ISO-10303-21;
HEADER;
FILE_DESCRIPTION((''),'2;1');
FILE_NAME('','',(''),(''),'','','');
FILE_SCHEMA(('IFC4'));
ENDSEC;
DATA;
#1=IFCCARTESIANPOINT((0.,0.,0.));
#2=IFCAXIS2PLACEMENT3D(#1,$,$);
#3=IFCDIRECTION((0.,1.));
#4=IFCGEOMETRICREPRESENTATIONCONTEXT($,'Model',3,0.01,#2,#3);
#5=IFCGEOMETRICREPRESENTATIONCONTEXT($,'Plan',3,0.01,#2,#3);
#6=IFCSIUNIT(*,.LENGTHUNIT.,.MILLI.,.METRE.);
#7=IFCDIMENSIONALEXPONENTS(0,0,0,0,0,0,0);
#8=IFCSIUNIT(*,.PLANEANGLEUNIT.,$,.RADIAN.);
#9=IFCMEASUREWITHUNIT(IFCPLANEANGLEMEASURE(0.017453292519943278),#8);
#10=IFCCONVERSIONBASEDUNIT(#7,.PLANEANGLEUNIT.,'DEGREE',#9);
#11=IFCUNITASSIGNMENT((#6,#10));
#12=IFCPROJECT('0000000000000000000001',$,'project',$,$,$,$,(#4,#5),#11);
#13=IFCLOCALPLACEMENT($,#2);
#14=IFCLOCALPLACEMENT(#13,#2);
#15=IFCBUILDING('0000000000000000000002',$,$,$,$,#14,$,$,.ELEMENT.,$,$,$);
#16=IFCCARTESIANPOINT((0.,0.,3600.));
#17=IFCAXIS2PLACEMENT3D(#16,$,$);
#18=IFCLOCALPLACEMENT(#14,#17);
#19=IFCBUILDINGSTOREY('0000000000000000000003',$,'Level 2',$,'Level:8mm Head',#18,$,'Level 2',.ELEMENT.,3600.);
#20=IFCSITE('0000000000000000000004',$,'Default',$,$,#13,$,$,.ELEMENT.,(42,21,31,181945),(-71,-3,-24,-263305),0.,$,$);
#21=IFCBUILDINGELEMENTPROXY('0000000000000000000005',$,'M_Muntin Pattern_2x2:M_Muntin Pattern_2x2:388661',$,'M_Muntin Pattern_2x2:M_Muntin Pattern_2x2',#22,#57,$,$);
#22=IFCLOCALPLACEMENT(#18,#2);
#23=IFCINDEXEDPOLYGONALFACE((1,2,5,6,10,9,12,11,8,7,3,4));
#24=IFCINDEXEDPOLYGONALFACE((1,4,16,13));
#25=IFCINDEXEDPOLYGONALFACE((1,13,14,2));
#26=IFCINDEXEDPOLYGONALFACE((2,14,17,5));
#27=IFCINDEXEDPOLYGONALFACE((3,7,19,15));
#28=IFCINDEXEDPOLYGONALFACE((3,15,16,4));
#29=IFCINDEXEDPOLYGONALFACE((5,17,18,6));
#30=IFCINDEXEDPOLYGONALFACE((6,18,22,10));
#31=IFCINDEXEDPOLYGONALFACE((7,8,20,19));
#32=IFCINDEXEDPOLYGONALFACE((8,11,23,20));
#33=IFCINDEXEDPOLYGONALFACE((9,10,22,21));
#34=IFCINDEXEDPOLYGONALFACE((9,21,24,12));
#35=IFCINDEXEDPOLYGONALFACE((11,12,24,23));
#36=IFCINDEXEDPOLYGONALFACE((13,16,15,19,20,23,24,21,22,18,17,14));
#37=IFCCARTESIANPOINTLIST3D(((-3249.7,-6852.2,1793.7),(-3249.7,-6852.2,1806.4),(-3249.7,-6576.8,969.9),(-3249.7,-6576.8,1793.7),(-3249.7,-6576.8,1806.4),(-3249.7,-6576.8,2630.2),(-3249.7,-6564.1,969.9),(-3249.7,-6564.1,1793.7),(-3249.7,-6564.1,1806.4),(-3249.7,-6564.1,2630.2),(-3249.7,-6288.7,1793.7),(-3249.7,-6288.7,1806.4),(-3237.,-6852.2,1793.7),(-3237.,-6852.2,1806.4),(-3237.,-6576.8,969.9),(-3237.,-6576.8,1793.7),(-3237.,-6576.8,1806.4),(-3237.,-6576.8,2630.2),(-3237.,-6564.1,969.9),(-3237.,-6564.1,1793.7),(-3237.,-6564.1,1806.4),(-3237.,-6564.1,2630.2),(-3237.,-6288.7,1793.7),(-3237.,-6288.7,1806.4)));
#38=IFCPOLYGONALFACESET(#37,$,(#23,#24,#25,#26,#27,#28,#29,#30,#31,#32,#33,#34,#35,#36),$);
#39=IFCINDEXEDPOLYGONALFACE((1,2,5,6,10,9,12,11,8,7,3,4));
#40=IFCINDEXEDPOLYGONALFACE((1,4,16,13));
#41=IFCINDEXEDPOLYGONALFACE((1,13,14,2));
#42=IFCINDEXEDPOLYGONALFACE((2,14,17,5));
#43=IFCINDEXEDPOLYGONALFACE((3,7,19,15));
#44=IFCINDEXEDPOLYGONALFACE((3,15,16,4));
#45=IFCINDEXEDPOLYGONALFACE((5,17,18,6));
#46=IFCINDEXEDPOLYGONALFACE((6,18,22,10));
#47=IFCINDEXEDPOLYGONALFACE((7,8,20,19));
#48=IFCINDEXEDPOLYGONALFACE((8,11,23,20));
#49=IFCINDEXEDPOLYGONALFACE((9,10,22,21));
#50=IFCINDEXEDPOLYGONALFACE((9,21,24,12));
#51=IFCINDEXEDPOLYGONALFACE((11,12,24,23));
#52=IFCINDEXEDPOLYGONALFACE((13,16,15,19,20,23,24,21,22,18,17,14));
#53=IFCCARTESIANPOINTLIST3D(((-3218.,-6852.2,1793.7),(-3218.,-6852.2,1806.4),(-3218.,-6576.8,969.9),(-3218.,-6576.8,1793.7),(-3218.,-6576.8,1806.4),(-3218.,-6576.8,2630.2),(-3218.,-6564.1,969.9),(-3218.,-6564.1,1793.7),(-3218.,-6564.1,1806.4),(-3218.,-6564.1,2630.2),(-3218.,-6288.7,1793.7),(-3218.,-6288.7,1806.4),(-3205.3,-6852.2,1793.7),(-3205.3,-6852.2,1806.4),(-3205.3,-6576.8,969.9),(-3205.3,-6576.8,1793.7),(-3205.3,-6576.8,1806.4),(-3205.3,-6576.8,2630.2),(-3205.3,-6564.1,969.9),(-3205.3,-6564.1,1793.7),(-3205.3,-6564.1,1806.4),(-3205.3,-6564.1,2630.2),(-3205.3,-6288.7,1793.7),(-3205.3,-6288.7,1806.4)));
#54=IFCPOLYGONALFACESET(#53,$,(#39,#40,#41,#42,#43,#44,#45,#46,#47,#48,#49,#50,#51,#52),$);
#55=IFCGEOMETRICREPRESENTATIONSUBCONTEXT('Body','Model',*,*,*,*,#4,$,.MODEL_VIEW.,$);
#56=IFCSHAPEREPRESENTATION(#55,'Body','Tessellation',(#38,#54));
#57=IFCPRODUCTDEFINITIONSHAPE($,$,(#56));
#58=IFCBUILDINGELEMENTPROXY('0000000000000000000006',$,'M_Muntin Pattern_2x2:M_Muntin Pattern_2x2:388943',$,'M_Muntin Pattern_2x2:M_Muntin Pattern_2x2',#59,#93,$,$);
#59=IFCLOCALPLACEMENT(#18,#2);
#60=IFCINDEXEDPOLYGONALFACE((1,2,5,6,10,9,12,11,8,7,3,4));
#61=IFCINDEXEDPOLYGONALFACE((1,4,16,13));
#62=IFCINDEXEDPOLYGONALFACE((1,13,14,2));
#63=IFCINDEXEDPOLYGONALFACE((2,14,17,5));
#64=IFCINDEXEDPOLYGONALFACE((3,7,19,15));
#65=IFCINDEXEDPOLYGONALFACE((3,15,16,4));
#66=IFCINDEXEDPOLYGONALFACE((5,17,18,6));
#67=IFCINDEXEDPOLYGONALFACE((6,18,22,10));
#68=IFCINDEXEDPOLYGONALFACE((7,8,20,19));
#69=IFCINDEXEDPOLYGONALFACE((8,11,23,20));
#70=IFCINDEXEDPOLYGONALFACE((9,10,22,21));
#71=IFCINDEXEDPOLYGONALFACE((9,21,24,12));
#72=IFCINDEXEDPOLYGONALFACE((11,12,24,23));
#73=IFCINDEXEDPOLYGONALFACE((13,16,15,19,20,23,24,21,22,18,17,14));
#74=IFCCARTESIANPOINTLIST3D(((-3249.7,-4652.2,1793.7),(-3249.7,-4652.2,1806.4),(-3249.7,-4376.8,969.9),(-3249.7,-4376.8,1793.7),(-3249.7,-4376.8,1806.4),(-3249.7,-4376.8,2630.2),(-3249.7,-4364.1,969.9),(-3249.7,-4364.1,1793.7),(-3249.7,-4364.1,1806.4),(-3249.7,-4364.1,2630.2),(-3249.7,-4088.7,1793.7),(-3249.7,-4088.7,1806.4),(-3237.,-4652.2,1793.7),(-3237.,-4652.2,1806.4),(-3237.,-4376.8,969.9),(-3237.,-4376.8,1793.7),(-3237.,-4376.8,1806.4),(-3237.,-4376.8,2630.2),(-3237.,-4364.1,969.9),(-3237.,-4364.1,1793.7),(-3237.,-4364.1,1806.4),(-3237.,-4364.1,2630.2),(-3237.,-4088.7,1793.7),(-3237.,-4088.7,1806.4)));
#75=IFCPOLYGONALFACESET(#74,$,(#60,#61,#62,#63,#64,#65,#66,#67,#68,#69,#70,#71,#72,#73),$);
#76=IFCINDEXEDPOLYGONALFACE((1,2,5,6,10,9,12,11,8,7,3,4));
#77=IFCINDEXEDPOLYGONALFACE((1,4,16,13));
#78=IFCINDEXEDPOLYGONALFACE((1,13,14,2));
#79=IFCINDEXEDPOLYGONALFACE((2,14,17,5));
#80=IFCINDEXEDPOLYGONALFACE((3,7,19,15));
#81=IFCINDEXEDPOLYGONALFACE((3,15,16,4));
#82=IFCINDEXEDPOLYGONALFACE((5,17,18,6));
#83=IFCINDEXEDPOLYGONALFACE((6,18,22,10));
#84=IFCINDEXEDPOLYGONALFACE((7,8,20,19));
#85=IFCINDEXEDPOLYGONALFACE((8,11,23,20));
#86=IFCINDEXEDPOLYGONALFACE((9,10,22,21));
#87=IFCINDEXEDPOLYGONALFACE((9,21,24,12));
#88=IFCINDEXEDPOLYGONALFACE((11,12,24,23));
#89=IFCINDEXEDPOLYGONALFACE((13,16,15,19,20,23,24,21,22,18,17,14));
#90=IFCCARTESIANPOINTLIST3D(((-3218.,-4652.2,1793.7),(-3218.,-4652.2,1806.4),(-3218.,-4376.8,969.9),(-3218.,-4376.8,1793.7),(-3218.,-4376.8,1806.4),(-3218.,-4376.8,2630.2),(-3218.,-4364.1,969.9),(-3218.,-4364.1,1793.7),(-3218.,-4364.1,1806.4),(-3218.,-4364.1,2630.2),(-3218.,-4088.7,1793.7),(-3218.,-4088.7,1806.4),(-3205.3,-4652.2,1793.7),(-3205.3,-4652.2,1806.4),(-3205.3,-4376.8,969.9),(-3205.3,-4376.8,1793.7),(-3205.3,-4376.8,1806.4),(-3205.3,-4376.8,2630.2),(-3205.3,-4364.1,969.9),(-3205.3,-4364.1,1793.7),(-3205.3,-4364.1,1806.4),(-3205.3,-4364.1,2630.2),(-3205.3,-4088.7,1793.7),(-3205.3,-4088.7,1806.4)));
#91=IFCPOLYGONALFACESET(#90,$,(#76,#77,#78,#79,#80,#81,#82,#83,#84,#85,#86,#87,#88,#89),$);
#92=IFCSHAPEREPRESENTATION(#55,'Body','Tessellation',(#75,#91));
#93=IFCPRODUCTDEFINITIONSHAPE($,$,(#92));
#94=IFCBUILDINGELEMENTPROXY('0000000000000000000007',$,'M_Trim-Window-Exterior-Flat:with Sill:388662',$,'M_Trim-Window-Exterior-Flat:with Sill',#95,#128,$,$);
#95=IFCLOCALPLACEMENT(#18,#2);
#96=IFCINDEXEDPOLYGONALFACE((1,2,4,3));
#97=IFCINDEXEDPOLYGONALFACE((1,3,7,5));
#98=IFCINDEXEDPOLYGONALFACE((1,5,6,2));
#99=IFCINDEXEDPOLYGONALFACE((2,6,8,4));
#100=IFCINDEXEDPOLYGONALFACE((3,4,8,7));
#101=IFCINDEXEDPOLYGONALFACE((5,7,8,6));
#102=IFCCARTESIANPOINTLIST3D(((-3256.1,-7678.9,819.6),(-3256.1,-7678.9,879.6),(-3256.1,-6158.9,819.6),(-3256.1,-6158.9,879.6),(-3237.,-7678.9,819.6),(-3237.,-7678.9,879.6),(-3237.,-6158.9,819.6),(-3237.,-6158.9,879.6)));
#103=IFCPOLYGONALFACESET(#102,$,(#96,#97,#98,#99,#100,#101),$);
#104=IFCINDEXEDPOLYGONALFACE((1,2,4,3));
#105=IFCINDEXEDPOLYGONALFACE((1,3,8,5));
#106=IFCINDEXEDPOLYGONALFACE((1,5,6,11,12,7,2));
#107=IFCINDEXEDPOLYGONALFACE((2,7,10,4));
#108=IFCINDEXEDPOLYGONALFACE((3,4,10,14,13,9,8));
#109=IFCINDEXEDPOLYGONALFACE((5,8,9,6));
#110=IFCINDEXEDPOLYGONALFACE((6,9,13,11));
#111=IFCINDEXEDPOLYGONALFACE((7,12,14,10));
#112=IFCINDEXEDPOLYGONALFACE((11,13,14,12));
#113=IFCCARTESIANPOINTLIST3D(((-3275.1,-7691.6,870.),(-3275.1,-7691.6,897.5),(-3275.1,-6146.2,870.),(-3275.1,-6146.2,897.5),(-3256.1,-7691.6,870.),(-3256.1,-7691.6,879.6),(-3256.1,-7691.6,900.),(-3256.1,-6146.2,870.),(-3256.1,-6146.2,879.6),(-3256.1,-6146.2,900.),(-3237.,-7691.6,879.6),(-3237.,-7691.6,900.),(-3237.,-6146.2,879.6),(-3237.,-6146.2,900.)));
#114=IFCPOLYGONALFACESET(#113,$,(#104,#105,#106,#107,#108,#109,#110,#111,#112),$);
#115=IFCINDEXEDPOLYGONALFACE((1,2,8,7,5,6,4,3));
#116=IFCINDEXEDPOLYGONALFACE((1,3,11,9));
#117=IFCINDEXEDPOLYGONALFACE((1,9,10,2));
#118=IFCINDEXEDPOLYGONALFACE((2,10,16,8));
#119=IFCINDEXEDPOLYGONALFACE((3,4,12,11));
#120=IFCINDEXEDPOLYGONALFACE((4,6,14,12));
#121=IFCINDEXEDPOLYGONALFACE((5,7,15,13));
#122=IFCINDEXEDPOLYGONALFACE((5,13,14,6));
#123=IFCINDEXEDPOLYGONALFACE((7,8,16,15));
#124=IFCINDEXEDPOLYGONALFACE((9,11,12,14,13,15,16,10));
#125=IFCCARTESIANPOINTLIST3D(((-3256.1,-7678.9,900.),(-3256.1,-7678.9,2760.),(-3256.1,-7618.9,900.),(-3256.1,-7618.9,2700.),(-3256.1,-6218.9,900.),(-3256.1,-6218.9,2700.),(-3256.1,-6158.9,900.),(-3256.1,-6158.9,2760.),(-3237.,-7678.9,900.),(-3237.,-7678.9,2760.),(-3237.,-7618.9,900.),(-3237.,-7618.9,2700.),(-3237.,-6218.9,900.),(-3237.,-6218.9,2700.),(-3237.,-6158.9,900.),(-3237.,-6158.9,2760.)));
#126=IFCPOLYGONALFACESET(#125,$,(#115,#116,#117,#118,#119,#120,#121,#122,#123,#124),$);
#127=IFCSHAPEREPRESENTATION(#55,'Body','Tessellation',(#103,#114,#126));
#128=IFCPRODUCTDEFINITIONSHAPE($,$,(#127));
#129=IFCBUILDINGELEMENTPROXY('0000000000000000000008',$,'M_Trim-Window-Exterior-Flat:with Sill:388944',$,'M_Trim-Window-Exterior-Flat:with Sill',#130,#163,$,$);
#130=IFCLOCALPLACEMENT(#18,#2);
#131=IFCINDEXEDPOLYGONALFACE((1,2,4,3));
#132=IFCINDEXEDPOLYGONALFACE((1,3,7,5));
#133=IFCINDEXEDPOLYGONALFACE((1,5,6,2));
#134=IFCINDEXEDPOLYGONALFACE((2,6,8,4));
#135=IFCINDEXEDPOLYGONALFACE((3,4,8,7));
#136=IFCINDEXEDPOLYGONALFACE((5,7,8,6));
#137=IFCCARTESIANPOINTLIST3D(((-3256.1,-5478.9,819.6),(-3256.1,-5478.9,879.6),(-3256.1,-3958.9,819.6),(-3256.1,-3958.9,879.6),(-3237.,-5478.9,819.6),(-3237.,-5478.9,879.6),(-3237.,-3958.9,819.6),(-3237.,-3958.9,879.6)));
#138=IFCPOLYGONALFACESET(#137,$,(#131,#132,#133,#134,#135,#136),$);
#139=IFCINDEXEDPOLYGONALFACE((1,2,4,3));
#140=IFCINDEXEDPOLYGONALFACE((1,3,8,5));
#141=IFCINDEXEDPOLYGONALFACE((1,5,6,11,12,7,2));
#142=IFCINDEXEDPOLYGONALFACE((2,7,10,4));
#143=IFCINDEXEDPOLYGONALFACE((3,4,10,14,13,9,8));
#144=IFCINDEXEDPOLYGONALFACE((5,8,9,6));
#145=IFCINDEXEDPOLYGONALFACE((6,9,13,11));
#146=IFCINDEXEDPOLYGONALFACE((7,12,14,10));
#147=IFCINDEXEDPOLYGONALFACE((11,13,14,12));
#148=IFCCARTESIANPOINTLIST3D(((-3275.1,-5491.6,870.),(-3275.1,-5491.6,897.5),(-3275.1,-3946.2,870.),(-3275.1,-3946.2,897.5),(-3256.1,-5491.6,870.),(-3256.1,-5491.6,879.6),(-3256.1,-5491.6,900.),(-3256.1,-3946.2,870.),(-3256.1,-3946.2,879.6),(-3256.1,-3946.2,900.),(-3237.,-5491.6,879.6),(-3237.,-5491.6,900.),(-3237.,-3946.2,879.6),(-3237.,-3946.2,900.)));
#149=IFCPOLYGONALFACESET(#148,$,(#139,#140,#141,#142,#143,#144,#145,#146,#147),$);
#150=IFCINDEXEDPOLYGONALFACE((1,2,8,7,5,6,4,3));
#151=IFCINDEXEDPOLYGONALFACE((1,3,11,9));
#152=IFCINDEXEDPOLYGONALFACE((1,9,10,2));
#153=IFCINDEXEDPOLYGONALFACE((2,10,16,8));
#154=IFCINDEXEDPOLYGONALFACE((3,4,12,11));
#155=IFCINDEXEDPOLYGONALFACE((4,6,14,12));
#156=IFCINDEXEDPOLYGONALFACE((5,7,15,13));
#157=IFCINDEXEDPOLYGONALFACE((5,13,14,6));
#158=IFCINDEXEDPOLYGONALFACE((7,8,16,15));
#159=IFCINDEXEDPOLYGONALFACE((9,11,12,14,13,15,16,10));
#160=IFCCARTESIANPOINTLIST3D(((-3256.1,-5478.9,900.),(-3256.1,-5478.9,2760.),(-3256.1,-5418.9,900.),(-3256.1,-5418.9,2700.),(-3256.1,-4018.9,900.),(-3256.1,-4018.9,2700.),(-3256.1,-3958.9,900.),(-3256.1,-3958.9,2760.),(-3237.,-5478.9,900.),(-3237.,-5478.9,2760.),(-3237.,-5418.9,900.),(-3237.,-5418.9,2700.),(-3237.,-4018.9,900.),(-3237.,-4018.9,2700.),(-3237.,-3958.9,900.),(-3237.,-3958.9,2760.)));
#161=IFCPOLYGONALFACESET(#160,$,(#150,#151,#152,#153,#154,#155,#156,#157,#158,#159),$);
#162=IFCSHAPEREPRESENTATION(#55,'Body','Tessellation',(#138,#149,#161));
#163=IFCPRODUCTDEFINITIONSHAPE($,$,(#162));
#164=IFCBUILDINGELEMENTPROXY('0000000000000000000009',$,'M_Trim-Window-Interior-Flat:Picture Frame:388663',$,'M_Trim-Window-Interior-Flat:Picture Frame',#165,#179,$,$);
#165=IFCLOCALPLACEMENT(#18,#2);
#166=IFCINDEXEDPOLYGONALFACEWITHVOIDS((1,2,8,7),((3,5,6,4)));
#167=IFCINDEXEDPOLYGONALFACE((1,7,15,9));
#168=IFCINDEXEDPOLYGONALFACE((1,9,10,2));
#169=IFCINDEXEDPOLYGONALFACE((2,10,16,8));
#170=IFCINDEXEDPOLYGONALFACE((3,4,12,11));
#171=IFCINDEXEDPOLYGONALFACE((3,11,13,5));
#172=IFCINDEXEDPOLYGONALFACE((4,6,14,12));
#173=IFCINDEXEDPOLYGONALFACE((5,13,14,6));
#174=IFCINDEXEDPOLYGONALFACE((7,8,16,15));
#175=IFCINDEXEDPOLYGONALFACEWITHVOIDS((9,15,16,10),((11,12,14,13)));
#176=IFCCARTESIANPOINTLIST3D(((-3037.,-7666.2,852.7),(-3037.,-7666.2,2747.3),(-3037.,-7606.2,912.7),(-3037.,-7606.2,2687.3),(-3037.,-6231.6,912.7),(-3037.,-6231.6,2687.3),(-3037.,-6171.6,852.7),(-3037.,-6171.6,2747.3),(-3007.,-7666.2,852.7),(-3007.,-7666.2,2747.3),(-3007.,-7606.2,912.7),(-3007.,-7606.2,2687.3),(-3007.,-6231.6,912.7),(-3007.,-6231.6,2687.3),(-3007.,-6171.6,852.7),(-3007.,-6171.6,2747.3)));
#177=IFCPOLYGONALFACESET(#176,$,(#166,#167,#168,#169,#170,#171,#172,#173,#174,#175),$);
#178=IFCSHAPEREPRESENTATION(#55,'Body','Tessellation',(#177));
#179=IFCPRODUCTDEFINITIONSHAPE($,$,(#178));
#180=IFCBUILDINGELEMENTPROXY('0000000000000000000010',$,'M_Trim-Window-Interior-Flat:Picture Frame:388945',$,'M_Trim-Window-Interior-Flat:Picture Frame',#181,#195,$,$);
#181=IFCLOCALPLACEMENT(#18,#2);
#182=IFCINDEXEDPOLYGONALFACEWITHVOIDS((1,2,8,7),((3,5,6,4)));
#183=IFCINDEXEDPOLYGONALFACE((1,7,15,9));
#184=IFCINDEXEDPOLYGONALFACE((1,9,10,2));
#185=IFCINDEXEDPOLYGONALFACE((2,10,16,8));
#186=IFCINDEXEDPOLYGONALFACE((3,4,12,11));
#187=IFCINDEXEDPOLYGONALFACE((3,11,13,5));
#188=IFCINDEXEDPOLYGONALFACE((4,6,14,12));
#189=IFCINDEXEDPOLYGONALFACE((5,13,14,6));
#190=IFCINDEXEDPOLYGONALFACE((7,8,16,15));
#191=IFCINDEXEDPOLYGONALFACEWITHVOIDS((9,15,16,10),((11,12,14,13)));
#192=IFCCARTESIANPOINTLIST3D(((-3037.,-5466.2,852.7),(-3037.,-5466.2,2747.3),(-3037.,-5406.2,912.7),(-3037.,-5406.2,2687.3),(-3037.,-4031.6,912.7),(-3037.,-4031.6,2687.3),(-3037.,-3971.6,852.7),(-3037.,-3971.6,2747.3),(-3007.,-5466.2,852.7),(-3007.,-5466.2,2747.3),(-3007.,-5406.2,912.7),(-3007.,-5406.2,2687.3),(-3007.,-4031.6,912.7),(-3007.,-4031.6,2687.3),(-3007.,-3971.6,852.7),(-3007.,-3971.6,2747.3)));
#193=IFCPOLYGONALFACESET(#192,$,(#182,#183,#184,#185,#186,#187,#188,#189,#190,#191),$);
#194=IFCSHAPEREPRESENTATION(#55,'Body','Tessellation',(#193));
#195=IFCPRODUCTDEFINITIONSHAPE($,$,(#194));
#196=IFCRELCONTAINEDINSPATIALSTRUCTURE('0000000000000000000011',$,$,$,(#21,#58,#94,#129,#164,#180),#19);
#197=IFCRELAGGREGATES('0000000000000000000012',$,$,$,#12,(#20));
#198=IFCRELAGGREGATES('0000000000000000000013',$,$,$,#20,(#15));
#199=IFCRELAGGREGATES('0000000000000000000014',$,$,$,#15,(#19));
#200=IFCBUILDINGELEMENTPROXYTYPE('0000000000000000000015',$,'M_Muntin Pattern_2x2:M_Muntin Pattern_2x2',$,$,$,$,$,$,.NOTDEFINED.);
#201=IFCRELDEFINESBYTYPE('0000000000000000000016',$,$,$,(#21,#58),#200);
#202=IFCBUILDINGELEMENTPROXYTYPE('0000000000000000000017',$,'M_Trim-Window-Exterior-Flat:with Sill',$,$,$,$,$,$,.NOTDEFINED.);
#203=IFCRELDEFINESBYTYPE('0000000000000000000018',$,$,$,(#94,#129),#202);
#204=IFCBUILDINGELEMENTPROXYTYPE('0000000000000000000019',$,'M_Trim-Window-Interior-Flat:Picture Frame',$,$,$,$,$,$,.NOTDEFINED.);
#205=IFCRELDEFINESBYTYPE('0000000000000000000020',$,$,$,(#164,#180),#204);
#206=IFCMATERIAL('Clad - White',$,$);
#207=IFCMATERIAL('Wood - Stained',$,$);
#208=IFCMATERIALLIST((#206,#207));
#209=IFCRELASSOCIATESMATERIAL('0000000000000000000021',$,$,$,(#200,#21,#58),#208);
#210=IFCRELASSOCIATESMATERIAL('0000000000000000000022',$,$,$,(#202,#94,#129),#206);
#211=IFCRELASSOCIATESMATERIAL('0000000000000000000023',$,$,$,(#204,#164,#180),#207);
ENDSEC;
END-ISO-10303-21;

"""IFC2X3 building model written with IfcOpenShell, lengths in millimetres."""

from ifc_helpers import new_model, entity, si_unit, converted_unit, direction, frame, frame_2d, origin, place, context, subcontext, project, spatial, polyline, rectangle, outline, extrude, source, transform, mapped, material, material_list, type_object, type_shapes, element, save


model = new_model("IFC2X3")

# Units and contexts
model_context = context("Model", 3, precision=0.01, world=origin(), true_north=direction((0.0, 1.0)))
plan_context = context("Plan", 3, precision=0.01, world=origin(), true_north=direction((0.0, 1.0)))
body_context = subcontext(model_context, "Body", "Model", "MODEL_VIEW")
ifc_project = project(units=[si_unit("LENGTHUNIT", "METRE", prefix="MILLI"), converted_unit("PLANEANGLEUNIT", "DEGREE", entity("IfcPlaneAngleMeasure", 0.017453292519943278), si_unit("PLANEANGLEUNIT", "RADIAN"), dimensions=[0, 0, 0, 0, 0, 0, 0])], contexts=[model_context, plan_context])

# Site, building, storey
site_placement = place(None, origin())
site = spatial("IfcSite", under=ifc_project, at=site_placement, Name="Default", CompositionType="ELEMENT", RefLatitude=(42, 21, 31, 181945), RefLongitude=(-71, -3, -24, -263305), RefElevation=0.0)
building_placement = place(site_placement, origin())
building = spatial("IfcBuilding", under=site, at=building_placement, CompositionType="ELEMENT")
storey_placement = place(building_placement, frame((0.0, 0.0, 3600.0)))
storey = spatial("IfcBuildingStorey", under=building, at=storey_placement, Name="Level 2", ObjectType="Level:8mm Head", LongName="Level 2", CompositionType="ELEMENT", Elevation=3600.0)

# Building element proxies
ifc_material_1 = material(Name="Clad - White")
ifc_material_2 = material(Name="Wood - Stained")
ifc_material_list = material_list([ifc_material_1, ifc_material_2])
building_element_proxy_type_1 = type_object("IfcBuildingElementProxyType", Name="M_Muntin Pattern_2x2:M_Muntin Pattern_2x2", PredefinedType="NOTDEFINED", material=ifc_material_list)
shared_shape_1 = source(origin(), body_context, "Body", "SweptSolid", [
    extrude(outline(polyline([(6.4, -6.4), (830.1, -6.4), (830.1, 6.3), (6.4, 6.3), (6.4, 281.7), (-6.3, 281.7), (-6.3, 6.3), (-830.2, 6.3), (-830.2, -6.4), (-6.3, -6.4), (-6.3, -281.7), (6.4, -281.7), (6.4, -6.4)])), frame((0.0, -22.2, 830.1), z_axis=(0.0, 1.0, 0.0), x_axis=(0.0, 0.0, 1.0)), (0.0, 0.0, 1.0), 12.7),
    extrude(outline(polyline([(6.4, -6.4), (830.2, -6.4), (830.2, 6.3), (6.4, 6.3), (6.4, 281.7), (-6.3, 281.7), (-6.3, 6.3), (-830.2, 6.3), (-830.2, -6.4), (-6.3, -6.4), (-6.3, -281.7), (6.4, -281.7), (6.4, -6.4)])), frame((0.0, 9.5, 830.2), z_axis=(0.0, 1.0, 0.0), x_axis=(0.0, 0.0, 1.0)), (0.0, 0.0, 1.0), 12.7),
])
type_shapes(building_element_proxy_type_1, [shared_shape_1])
for number, where, z_axis, x_axis, name in (
    (1, (-3227.5, -6570.5, 969.9), (0.0, 0.0, 1.0), (0.0, -1.0, 0.0), "M_Muntin Pattern_2x2:M_Muntin Pattern_2x2:388661"),
    (2, (-3227.5, -4370.5, 969.9), (0.0, 0.0, 1.0), (0.0, -1.0, 0.0), "M_Muntin Pattern_2x2:M_Muntin Pattern_2x2:388943"),
):
    element("IfcBuildingElementProxy", number, at=place(storey_placement, frame(where, z_axis=z_axis, x_axis=x_axis)), inside=storey, type_object=building_element_proxy_type_1, material=ifc_material_list, Name=name, ObjectType="M_Muntin Pattern_2x2:M_Muntin Pattern_2x2", context=body_context, shape_type="MappedRepresentation", body=[
        mapped(shared_shape_1, transform((0.0, 0.0, 0.0), scale=1.0)),
    ])
building_element_proxy_type_2 = type_object("IfcBuildingElementProxyType", Name="M_Trim-Window-Exterior-Flat:with Sill", PredefinedType="NOTDEFINED", material=ifc_material_1)
shared_shape_2 = source(origin(), body_context, "Body", "SweptSolid", [
    extrude(rectangle(XDim=1520.0, YDim=60.0, at=frame_2d((0.0, 0.0), x_axis=(1.0, 0.0))), frame((0.0, -1850.4, 0.0), z_axis=(0.0, 0.0, 1.0), x_axis=(-1.0, 0.0, 0.0)), (0.0, 0.0, 1.0), 19.0),
    extrude(outline(polyline([(-19.0, -15.2), (0.0, -15.2), (0.0, -5.7), (19.0, -5.7), (19.0, 14.8), (0.0, 14.8), (-19.0, 12.3), (-19.0, -15.2)])), frame((-772.7, -1814.8, 19.0), z_axis=(1.0, 0.0, 0.0), x_axis=(0.0, 0.0, -1.0)), (0.0, 0.0, 1.0), 1545.4),
    extrude(outline(polyline([(-945.0, -760.0), (915.0, -760.0), (915.0, -700.0), (-885.0, -700.0), (-885.0, 700.0), (915.0, 700.0), (915.0, 760.0), (-945.0, 760.0), (-945.0, -760.0)])), frame((0.0, -885.0, 0.0), z_axis=(0.0, 0.0, 1.0), x_axis=(0.0, -1.0, 0.0)), (0.0, 0.0, 1.0), 19.0),
])
type_shapes(building_element_proxy_type_2, [shared_shape_2])
for number, where, z_axis, x_axis, name in (
    (3, (-3237.0, -6918.9, 2700.0), (-1.0, 0.0, 0.0), (0.0, -1.0, 0.0), "M_Trim-Window-Exterior-Flat:with Sill:388662"),
    (4, (-3237.0, -4718.9, 2700.0), (-1.0, 0.0, 0.0), (0.0, -1.0, 0.0), "M_Trim-Window-Exterior-Flat:with Sill:388944"),
):
    element("IfcBuildingElementProxy", number, at=place(storey_placement, frame(where, z_axis=z_axis, x_axis=x_axis)), inside=storey, type_object=building_element_proxy_type_2, material=ifc_material_1, Name=name, ObjectType="M_Trim-Window-Exterior-Flat:with Sill", context=body_context, shape_type="MappedRepresentation", body=[
        mapped(shared_shape_2, transform((0.0, 0.0, 0.0), scale=1.0)),
    ])
building_element_proxy_type_3 = type_object("IfcBuildingElementProxyType", Name="M_Trim-Window-Interior-Flat:Picture Frame", PredefinedType="NOTDEFINED", material=ifc_material_2)
shared_shape_3 = source(origin(), body_context, "Body", "SweptSolid", [
    extrude(outline(polyline([(-747.3, -947.3), (747.3, -947.3), (747.3, 947.3), (-747.3, 947.3), (-747.3, -947.3)]), holes=[polyline([(-687.3, -887.3), (-687.3, 887.3), (687.3, 887.3), (687.3, -887.3), (-687.3, -887.3)])]), frame((0.0, -900.0, 0.0), z_axis=(0.0, 0.0, 1.0), x_axis=(-1.0, 0.0, 0.0)), (0.0, 0.0, 1.0), 30.0),
])
type_shapes(building_element_proxy_type_3, [shared_shape_3])
for number, where, z_axis, x_axis, name in (
    (5, (-3037.0, -6918.9, 2700.0), (1.0, 0.0, 0.0), (0.0, 1.0, 0.0), "M_Trim-Window-Interior-Flat:Picture Frame:388663"),
    (6, (-3037.0, -4718.9, 2700.0), (1.0, 0.0, 0.0), (0.0, 1.0, 0.0), "M_Trim-Window-Interior-Flat:Picture Frame:388945"),
):
    element("IfcBuildingElementProxy", number, at=place(storey_placement, frame(where, z_axis=z_axis, x_axis=x_axis)), inside=storey, type_object=building_element_proxy_type_3, material=ifc_material_2, Name=name, ObjectType="M_Trim-Window-Interior-Flat:Picture Frame", context=body_context, shape_type="MappedRepresentation", body=[
        mapped(shared_shape_3, transform((0.0, 0.0, 0.0), scale=1.0)),
    ])

save(model, "model.ifc")
